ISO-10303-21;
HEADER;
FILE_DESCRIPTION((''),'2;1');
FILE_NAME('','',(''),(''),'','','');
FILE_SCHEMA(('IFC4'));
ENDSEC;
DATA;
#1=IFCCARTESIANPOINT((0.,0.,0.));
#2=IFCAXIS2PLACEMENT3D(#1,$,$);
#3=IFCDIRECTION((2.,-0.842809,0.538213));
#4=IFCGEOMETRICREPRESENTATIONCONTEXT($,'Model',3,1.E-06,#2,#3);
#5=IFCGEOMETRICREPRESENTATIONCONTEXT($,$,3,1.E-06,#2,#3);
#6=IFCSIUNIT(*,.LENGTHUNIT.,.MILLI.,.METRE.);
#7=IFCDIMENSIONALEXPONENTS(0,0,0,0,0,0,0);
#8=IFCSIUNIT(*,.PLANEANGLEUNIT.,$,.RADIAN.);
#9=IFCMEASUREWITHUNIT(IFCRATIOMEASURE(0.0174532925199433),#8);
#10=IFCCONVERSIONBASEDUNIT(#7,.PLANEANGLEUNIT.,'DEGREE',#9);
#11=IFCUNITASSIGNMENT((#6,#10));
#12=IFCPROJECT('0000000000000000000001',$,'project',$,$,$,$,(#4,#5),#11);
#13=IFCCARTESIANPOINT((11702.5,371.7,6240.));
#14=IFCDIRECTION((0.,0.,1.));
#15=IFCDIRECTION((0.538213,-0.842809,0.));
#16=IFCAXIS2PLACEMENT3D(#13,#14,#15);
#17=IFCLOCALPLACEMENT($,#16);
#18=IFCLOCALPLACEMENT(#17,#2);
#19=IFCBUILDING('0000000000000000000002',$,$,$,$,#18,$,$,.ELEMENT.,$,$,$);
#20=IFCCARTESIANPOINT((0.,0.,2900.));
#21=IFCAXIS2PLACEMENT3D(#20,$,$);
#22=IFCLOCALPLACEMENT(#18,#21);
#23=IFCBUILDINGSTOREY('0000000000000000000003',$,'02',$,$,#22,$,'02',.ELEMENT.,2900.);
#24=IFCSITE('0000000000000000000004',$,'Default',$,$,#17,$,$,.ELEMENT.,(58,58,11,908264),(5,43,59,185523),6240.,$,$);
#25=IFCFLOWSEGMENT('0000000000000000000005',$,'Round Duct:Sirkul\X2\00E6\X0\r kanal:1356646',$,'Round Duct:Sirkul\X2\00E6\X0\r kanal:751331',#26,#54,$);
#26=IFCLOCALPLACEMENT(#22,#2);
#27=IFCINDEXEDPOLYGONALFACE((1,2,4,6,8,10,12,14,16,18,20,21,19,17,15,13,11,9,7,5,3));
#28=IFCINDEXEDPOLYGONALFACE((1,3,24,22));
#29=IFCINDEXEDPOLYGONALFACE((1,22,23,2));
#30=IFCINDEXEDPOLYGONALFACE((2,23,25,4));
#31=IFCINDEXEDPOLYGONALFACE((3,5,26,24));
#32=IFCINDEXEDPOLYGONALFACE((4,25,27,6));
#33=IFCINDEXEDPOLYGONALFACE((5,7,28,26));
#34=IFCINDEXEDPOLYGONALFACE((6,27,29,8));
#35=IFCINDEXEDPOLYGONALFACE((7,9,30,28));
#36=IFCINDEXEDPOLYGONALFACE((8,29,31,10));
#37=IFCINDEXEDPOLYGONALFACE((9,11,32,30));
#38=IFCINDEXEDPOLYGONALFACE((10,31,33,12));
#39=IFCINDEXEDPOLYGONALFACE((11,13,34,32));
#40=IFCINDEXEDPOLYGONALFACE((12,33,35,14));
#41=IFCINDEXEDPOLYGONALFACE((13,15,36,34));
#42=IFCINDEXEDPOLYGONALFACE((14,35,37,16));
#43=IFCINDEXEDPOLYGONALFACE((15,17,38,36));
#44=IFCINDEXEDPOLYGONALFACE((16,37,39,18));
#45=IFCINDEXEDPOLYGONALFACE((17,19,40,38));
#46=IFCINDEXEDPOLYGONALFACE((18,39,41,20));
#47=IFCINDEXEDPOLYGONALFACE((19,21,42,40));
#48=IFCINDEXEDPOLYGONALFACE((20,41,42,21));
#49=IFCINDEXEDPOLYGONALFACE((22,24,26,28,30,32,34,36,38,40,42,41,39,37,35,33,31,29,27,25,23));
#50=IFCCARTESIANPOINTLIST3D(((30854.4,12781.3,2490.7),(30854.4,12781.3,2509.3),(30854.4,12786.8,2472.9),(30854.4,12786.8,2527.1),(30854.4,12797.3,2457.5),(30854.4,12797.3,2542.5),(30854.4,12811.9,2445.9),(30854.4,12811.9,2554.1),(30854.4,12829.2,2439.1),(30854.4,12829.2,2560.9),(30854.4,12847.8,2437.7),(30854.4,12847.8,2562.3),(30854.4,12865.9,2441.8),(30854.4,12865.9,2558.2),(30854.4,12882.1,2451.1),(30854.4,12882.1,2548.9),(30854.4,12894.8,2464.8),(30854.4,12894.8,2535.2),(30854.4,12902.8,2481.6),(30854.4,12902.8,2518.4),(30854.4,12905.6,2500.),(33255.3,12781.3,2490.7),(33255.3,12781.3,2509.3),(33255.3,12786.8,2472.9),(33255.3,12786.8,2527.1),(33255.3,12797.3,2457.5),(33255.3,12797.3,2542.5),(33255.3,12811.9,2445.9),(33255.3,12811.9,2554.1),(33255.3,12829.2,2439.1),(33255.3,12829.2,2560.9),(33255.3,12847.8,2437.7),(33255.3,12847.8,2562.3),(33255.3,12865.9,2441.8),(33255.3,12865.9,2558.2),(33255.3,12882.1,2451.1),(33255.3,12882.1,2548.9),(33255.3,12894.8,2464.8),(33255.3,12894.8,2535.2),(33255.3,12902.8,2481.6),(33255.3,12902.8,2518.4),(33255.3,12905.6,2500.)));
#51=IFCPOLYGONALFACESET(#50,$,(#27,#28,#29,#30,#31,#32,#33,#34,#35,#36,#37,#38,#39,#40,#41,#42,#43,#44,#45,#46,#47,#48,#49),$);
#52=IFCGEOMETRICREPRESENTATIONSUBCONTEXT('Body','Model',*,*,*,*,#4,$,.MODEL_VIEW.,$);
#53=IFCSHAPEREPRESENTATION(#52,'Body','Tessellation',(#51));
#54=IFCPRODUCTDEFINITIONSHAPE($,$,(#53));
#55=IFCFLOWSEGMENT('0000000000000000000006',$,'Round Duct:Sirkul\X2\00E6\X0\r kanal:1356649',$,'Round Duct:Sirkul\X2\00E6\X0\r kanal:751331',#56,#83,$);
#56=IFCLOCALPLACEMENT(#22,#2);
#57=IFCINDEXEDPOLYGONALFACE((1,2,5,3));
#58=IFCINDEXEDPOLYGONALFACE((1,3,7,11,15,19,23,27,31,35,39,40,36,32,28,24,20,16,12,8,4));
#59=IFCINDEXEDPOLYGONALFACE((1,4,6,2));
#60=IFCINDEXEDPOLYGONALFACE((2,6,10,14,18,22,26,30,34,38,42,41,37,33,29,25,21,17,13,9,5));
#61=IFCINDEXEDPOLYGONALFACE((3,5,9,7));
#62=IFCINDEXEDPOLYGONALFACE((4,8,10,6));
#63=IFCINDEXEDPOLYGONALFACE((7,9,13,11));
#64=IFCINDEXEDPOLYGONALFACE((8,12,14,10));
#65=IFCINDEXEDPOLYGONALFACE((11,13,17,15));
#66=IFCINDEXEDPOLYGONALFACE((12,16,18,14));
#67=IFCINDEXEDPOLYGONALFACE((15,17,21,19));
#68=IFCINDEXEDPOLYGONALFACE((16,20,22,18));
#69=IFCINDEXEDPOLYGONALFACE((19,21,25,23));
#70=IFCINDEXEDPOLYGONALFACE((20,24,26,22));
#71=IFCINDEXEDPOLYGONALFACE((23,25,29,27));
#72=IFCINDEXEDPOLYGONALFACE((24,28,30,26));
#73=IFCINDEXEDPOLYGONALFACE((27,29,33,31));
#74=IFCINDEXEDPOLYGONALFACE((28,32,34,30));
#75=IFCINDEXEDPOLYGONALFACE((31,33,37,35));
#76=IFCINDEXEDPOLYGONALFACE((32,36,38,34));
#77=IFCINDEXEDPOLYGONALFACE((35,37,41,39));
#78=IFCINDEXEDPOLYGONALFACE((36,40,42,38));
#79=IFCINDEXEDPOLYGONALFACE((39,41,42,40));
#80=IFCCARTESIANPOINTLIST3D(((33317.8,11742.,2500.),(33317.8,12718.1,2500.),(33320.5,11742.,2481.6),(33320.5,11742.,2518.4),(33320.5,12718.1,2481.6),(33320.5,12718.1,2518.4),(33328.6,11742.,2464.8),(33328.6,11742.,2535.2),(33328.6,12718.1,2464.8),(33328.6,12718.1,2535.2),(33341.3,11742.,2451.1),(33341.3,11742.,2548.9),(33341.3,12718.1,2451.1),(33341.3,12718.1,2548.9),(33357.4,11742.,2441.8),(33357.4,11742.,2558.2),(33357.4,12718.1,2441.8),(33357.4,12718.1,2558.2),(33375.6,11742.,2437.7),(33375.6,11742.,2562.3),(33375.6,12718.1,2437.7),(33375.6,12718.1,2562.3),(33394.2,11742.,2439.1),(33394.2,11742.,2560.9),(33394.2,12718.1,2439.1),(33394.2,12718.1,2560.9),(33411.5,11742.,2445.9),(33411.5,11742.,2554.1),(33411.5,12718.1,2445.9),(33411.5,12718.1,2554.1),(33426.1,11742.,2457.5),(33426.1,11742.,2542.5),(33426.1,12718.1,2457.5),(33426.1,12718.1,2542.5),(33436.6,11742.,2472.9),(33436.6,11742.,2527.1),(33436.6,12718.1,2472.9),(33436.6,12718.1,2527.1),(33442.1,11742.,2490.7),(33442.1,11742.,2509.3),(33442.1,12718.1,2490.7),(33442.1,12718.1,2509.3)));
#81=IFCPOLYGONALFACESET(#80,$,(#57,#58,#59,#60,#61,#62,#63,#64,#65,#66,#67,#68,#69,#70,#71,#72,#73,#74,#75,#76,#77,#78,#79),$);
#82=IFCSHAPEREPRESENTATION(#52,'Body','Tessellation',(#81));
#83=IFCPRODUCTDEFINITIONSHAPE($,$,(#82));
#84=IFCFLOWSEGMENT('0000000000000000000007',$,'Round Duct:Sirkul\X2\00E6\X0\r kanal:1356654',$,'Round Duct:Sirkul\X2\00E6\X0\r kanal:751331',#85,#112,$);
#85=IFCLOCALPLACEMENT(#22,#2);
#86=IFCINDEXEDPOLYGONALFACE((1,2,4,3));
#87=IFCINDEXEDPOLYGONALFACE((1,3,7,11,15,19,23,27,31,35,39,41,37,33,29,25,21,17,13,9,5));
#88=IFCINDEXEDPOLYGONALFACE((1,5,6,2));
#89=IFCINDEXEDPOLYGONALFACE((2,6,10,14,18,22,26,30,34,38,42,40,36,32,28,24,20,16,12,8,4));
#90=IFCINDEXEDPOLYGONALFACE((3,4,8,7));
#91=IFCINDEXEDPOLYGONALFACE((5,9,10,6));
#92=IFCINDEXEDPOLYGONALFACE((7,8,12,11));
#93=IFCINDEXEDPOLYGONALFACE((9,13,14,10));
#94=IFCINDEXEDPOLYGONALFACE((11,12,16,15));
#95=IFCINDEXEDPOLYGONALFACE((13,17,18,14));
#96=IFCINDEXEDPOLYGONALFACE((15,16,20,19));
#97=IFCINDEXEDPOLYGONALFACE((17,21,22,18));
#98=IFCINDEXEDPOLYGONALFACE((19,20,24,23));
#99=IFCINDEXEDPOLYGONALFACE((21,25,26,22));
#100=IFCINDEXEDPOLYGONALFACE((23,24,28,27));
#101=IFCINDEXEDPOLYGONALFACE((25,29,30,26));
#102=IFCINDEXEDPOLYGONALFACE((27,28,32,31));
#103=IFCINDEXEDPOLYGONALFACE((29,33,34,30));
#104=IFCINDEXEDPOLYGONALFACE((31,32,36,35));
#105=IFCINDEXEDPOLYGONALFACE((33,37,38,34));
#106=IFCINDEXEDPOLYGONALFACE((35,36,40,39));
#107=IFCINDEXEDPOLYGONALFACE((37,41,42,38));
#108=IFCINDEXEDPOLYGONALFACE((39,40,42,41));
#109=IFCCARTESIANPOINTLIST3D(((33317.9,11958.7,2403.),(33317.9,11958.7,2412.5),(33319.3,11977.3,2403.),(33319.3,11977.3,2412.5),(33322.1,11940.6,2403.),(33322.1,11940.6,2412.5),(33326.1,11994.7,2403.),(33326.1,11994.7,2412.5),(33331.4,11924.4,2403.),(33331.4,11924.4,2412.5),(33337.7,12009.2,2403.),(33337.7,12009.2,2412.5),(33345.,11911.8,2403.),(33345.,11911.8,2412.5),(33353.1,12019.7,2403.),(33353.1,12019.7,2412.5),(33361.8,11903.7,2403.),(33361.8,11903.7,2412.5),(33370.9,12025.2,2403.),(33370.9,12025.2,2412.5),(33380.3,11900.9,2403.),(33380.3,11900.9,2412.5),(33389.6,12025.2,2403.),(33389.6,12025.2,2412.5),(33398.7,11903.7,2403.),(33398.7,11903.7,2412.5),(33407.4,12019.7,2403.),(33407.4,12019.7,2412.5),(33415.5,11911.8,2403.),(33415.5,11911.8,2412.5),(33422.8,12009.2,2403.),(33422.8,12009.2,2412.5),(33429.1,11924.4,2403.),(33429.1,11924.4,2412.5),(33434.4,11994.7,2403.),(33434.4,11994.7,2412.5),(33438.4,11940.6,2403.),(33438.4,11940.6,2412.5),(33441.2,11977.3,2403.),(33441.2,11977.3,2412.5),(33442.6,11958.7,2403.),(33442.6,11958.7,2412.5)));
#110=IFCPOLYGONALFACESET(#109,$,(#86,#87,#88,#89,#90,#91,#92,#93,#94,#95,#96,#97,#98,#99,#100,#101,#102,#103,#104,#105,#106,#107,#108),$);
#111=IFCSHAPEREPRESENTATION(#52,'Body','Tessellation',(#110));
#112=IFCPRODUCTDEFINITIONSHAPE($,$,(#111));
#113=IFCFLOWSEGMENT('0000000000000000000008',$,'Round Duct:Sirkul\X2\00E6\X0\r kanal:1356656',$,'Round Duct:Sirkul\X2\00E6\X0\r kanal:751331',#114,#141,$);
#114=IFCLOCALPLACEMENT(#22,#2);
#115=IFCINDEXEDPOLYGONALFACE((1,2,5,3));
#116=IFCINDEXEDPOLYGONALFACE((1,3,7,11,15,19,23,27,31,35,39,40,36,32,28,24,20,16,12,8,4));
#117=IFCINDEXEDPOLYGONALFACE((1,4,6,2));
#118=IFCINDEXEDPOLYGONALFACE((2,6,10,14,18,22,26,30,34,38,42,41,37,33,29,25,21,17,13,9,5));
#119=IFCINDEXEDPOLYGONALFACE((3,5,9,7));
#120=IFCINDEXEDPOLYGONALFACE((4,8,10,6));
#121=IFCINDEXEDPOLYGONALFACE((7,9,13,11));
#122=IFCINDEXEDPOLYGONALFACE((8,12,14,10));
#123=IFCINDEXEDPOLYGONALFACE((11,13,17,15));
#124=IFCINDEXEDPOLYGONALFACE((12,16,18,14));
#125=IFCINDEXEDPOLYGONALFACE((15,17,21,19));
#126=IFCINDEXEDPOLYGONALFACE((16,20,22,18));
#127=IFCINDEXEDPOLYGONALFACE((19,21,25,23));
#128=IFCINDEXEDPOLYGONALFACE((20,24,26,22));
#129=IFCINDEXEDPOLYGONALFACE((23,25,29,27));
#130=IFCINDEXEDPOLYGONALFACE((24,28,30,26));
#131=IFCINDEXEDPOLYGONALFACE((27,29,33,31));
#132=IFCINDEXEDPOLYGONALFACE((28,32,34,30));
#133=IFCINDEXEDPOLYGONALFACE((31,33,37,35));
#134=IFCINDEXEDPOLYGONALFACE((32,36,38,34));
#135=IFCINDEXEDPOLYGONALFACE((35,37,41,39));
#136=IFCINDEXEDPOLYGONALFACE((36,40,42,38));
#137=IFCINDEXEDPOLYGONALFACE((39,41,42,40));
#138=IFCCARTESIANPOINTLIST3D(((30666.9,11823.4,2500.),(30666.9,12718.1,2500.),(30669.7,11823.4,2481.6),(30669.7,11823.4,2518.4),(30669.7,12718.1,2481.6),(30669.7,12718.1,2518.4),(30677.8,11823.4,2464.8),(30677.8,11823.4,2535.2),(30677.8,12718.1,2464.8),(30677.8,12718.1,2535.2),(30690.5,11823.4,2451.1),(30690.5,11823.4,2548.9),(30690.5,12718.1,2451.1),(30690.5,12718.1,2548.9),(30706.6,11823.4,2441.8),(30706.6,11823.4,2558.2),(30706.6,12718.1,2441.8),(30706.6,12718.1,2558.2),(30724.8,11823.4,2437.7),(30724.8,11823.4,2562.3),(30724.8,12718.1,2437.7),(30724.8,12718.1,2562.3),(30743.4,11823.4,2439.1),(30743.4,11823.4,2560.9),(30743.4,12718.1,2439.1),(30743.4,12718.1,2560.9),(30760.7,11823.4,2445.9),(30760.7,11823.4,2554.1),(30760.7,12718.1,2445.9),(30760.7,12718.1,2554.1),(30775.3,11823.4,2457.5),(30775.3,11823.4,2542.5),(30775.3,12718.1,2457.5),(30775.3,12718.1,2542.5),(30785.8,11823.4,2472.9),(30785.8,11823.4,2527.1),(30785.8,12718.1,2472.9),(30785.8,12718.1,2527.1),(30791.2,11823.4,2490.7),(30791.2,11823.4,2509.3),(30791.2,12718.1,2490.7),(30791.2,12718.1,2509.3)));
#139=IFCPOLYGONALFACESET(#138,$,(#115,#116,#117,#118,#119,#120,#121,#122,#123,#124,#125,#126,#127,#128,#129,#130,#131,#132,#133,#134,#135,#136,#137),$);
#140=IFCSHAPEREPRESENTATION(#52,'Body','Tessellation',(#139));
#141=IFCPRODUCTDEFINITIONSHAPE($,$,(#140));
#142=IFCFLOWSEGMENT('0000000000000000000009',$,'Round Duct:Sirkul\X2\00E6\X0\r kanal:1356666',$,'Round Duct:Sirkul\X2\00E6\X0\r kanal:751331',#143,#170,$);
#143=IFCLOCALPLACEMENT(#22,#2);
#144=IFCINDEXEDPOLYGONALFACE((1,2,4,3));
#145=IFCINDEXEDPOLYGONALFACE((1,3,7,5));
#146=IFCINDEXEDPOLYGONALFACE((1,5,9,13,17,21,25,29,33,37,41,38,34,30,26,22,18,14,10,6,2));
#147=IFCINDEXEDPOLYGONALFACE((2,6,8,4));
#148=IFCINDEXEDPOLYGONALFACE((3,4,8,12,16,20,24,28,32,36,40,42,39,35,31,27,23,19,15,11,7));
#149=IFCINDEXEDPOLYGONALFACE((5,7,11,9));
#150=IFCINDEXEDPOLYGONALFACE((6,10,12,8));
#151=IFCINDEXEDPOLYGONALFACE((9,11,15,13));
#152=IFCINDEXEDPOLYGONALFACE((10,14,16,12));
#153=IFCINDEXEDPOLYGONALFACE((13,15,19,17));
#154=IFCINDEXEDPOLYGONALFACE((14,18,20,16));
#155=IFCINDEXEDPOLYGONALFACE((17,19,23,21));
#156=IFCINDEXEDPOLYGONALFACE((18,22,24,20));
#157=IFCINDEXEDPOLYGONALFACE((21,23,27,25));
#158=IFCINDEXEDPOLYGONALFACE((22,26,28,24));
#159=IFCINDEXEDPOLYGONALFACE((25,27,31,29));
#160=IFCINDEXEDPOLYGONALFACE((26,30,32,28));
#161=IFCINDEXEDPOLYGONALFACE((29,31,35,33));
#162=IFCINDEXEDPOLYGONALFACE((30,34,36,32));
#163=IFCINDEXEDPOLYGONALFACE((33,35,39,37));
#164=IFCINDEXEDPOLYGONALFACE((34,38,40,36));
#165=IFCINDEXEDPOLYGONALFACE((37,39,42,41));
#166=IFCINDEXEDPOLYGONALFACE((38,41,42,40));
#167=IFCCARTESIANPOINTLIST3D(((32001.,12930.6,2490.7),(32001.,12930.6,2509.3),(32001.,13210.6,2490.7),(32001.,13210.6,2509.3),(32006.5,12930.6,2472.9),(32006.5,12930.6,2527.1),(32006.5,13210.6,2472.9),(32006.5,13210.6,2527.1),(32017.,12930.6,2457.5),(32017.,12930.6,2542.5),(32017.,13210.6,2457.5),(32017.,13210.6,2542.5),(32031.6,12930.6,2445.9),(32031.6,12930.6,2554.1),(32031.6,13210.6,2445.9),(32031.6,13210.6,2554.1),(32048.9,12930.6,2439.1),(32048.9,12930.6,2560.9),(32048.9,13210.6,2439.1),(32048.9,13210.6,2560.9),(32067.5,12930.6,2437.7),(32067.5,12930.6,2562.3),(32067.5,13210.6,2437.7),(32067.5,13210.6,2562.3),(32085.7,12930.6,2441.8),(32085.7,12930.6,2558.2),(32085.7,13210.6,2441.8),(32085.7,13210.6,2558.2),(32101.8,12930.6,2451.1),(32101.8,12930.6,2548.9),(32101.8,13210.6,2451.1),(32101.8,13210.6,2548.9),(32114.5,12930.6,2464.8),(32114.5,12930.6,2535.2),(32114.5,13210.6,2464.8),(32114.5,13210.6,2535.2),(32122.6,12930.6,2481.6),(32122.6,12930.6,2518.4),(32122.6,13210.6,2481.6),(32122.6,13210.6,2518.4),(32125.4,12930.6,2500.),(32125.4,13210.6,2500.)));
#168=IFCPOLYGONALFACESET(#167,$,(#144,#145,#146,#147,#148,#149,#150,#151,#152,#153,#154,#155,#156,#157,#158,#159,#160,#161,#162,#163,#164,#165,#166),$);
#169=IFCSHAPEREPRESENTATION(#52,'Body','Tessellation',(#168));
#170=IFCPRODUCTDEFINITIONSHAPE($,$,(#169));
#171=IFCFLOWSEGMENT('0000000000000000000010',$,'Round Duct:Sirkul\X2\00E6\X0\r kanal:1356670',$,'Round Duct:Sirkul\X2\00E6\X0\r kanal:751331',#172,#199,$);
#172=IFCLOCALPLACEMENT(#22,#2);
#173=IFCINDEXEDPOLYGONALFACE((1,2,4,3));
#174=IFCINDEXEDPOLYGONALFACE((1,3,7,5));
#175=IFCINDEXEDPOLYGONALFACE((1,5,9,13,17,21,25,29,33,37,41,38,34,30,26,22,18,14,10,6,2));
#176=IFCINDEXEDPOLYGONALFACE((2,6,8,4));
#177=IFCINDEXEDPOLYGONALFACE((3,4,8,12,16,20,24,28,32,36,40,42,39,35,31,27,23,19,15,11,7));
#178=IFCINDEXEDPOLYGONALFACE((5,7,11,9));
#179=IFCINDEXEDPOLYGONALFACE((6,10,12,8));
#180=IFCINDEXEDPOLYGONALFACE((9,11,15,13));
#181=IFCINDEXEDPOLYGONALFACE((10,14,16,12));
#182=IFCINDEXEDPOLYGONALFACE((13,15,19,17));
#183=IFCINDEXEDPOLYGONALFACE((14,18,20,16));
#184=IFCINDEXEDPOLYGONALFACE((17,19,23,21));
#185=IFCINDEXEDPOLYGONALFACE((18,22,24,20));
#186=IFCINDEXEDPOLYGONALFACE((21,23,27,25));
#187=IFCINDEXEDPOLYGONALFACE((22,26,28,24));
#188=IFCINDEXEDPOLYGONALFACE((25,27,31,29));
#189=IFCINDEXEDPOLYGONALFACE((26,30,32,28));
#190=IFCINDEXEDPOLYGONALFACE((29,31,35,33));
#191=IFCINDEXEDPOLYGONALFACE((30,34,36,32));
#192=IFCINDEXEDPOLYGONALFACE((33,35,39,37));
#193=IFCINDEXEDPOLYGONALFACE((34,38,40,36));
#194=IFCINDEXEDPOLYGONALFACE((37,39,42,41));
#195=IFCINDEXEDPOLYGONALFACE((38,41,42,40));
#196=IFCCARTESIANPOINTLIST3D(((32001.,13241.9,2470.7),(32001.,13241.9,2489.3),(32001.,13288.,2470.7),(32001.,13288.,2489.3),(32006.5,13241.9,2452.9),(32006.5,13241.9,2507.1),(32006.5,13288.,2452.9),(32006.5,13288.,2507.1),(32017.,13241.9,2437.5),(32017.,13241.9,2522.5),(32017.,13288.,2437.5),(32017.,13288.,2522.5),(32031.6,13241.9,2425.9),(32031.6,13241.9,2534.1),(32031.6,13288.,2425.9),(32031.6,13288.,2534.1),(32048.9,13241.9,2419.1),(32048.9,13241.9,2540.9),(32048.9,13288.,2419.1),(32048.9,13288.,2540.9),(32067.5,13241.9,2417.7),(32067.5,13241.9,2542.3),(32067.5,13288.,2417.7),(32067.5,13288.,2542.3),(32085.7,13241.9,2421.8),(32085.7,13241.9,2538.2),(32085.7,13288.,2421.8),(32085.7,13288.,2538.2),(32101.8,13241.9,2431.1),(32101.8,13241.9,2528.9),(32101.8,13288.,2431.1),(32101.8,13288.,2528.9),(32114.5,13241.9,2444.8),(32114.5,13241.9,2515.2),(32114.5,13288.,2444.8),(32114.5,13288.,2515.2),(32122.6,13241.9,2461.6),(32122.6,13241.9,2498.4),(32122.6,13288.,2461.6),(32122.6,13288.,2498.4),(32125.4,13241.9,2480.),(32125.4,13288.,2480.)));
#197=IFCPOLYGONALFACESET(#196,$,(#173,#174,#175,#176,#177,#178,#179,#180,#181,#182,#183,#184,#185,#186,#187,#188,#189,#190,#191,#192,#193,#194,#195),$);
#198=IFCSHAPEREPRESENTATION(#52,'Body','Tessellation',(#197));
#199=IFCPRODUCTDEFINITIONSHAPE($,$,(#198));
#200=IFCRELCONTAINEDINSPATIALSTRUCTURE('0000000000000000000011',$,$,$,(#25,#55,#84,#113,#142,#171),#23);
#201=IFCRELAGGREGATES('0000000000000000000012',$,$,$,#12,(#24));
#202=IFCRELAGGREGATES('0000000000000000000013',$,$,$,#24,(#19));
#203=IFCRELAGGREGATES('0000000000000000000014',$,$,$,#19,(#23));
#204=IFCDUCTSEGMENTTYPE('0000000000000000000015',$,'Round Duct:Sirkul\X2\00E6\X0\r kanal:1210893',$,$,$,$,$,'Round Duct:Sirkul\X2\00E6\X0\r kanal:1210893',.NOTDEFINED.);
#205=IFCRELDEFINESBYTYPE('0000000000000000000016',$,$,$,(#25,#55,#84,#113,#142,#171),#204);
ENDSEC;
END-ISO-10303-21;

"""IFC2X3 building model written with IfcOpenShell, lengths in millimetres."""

from ifc_helpers import new_model, entity, si_unit, converted_unit, direction, frame, frame_2d, origin, origin_2d_with_axis, place, context, subcontext, project, spatial, circle, extrude, type_object, element, save


model = new_model("IFC2X3")

# Units and contexts
model_context = context("Model", 3, precision=1e-06, world=origin(), true_north=direction((2.0, -0.842809, 0.538213)))
context_of_model = context(None, 3, precision=1e-06, world=origin(), true_north=direction((2.0, -0.842809, 0.538213)))
body_context = subcontext(model_context, "Body", "Model", "MODEL_VIEW")
ifc_project = project(units=[si_unit("LENGTHUNIT", "METRE", prefix="MILLI"), converted_unit("PLANEANGLEUNIT", "DEGREE", entity("IfcRatioMeasure", 0.0174532925199433), si_unit("PLANEANGLEUNIT", "RADIAN"), dimensions=[0, 0, 0, 0, 0, 0, 0])], contexts=[model_context, context_of_model])

# Site, building, storey
site_placement = place(None, frame((11702.5, 371.7, 6240.0), z_axis=(0.0, 0.0, 1.0), x_axis=(0.538213, -0.842809, 0.0)))
site = spatial("IfcSite", under=ifc_project, at=site_placement, Name="Default", CompositionType="ELEMENT", RefLatitude=(58, 58, 11, 908264), RefLongitude=(5, 43, 59, 185523), RefElevation=6240.0)
building_placement = place(site_placement, origin())
building = spatial("IfcBuilding", under=site, at=building_placement, CompositionType="ELEMENT")
storey_placement = place(building_placement, frame((0.0, 0.0, 2900.0)))
storey = spatial("IfcBuildingStorey", under=building, at=storey_placement, Name="02", LongName="02", CompositionType="ELEMENT", Elevation=2900.0)

# Flow segments
duct_segment_type = type_object("IfcDuctSegmentType", Name="Round Duct:Sirkulær kanal:1210893", ElementType="Round Duct:Sirkulær kanal:1210893", PredefinedType="NOTDEFINED")
flow_segment_1_placement = place(storey_placement, origin())
element("IfcFlowSegment", 1, at=flow_segment_1_placement, inside=storey, type_object=duct_segment_type, Name="Round Duct:Sirkulær kanal:1356646", ObjectType="Round Duct:Sirkulær kanal:751331", context=body_context, shape_type="SweptSolid", body=[
    extrude(circle(Radius=62.5, at=origin_2d_with_axis()), frame((30854.4, 12843.1, 2500.0), z_axis=(1.0, 0.0, 0.0), x_axis=(0.0, 1.0, 0.0)), (0.0, 0.0, 1.0), 2400.8),
])
flow_segment_2_placement = place(storey_placement, origin())
element("IfcFlowSegment", 2, at=flow_segment_2_placement, inside=storey, type_object=duct_segment_type, Name="Round Duct:Sirkulær kanal:1356649", ObjectType="Round Duct:Sirkulær kanal:751331", context=body_context, shape_type="SweptSolid", body=[
    extrude(circle(Radius=62.5, at=frame_2d((0.0, 0.0), x_axis=(1.0, 0.0))), frame((33380.3, 11742.0, 2500.0), z_axis=(0.0, 1.0, 0.0), x_axis=(-1.0, 0.0, 0.0)), (0.0, 0.0, 1.0), 976.1),
])
flow_segment_3_placement = place(storey_placement, origin())
element("IfcFlowSegment", 3, at=flow_segment_3_placement, inside=storey, type_object=duct_segment_type, Name="Round Duct:Sirkulær kanal:1356654", ObjectType="Round Duct:Sirkulær kanal:751331", context=body_context, shape_type="SweptSolid", body=[
    extrude(circle(Radius=62.5, at=frame_2d((0.0, 0.0), x_axis=(1.0, 0.0))), frame((33380.3, 11963.4, 2403.0), z_axis=(0.0, 0.0, 1.0), x_axis=(0.0, -1.0, 0.0)), (0.0, 0.0, 1.0), 9.5),
])
flow_segment_4_placement = place(storey_placement, origin())
element("IfcFlowSegment", 4, at=flow_segment_4_placement, inside=storey, type_object=duct_segment_type, Name="Round Duct:Sirkulær kanal:1356656", ObjectType="Round Duct:Sirkulær kanal:751331", context=body_context, shape_type="SweptSolid", body=[
    extrude(circle(Radius=62.5, at=frame_2d((0.0, 0.0), x_axis=(1.0, 0.0))), frame((30729.4, 11823.4, 2500.0), z_axis=(0.0, 1.0, 0.0), x_axis=(-1.0, 0.0, 0.0)), (0.0, 0.0, 1.0), 894.7),
])
flow_segment_5_placement = place(storey_placement, origin())
element("IfcFlowSegment", 5, at=flow_segment_5_placement, inside=storey, type_object=duct_segment_type, Name="Round Duct:Sirkulær kanal:1356666", ObjectType="Round Duct:Sirkulær kanal:751331", context=body_context, shape_type="SweptSolid", body=[
    extrude(circle(Radius=62.5, at=origin_2d_with_axis()), frame((32062.9, 12930.6, 2500.0), z_axis=(0.0, 1.0, 0.0), x_axis=(1.0, 0.0, 0.0)), (0.0, 0.0, 1.0), 280.0),
])
flow_segment_6_placement = place(storey_placement, origin())
element("IfcFlowSegment", 6, at=flow_segment_6_placement, inside=storey, type_object=duct_segment_type, Name="Round Duct:Sirkulær kanal:1356670", ObjectType="Round Duct:Sirkulær kanal:751331", context=body_context, shape_type="SweptSolid", body=[
    extrude(circle(Radius=62.5, at=origin_2d_with_axis()), frame((32062.9, 13241.9, 2480.0), z_axis=(0.0, 1.0, 0.0), x_axis=(1.0, 0.0, 0.0)), (0.0, 0.0, 1.0), 46.1),
])

save(model, "model.ifc")
